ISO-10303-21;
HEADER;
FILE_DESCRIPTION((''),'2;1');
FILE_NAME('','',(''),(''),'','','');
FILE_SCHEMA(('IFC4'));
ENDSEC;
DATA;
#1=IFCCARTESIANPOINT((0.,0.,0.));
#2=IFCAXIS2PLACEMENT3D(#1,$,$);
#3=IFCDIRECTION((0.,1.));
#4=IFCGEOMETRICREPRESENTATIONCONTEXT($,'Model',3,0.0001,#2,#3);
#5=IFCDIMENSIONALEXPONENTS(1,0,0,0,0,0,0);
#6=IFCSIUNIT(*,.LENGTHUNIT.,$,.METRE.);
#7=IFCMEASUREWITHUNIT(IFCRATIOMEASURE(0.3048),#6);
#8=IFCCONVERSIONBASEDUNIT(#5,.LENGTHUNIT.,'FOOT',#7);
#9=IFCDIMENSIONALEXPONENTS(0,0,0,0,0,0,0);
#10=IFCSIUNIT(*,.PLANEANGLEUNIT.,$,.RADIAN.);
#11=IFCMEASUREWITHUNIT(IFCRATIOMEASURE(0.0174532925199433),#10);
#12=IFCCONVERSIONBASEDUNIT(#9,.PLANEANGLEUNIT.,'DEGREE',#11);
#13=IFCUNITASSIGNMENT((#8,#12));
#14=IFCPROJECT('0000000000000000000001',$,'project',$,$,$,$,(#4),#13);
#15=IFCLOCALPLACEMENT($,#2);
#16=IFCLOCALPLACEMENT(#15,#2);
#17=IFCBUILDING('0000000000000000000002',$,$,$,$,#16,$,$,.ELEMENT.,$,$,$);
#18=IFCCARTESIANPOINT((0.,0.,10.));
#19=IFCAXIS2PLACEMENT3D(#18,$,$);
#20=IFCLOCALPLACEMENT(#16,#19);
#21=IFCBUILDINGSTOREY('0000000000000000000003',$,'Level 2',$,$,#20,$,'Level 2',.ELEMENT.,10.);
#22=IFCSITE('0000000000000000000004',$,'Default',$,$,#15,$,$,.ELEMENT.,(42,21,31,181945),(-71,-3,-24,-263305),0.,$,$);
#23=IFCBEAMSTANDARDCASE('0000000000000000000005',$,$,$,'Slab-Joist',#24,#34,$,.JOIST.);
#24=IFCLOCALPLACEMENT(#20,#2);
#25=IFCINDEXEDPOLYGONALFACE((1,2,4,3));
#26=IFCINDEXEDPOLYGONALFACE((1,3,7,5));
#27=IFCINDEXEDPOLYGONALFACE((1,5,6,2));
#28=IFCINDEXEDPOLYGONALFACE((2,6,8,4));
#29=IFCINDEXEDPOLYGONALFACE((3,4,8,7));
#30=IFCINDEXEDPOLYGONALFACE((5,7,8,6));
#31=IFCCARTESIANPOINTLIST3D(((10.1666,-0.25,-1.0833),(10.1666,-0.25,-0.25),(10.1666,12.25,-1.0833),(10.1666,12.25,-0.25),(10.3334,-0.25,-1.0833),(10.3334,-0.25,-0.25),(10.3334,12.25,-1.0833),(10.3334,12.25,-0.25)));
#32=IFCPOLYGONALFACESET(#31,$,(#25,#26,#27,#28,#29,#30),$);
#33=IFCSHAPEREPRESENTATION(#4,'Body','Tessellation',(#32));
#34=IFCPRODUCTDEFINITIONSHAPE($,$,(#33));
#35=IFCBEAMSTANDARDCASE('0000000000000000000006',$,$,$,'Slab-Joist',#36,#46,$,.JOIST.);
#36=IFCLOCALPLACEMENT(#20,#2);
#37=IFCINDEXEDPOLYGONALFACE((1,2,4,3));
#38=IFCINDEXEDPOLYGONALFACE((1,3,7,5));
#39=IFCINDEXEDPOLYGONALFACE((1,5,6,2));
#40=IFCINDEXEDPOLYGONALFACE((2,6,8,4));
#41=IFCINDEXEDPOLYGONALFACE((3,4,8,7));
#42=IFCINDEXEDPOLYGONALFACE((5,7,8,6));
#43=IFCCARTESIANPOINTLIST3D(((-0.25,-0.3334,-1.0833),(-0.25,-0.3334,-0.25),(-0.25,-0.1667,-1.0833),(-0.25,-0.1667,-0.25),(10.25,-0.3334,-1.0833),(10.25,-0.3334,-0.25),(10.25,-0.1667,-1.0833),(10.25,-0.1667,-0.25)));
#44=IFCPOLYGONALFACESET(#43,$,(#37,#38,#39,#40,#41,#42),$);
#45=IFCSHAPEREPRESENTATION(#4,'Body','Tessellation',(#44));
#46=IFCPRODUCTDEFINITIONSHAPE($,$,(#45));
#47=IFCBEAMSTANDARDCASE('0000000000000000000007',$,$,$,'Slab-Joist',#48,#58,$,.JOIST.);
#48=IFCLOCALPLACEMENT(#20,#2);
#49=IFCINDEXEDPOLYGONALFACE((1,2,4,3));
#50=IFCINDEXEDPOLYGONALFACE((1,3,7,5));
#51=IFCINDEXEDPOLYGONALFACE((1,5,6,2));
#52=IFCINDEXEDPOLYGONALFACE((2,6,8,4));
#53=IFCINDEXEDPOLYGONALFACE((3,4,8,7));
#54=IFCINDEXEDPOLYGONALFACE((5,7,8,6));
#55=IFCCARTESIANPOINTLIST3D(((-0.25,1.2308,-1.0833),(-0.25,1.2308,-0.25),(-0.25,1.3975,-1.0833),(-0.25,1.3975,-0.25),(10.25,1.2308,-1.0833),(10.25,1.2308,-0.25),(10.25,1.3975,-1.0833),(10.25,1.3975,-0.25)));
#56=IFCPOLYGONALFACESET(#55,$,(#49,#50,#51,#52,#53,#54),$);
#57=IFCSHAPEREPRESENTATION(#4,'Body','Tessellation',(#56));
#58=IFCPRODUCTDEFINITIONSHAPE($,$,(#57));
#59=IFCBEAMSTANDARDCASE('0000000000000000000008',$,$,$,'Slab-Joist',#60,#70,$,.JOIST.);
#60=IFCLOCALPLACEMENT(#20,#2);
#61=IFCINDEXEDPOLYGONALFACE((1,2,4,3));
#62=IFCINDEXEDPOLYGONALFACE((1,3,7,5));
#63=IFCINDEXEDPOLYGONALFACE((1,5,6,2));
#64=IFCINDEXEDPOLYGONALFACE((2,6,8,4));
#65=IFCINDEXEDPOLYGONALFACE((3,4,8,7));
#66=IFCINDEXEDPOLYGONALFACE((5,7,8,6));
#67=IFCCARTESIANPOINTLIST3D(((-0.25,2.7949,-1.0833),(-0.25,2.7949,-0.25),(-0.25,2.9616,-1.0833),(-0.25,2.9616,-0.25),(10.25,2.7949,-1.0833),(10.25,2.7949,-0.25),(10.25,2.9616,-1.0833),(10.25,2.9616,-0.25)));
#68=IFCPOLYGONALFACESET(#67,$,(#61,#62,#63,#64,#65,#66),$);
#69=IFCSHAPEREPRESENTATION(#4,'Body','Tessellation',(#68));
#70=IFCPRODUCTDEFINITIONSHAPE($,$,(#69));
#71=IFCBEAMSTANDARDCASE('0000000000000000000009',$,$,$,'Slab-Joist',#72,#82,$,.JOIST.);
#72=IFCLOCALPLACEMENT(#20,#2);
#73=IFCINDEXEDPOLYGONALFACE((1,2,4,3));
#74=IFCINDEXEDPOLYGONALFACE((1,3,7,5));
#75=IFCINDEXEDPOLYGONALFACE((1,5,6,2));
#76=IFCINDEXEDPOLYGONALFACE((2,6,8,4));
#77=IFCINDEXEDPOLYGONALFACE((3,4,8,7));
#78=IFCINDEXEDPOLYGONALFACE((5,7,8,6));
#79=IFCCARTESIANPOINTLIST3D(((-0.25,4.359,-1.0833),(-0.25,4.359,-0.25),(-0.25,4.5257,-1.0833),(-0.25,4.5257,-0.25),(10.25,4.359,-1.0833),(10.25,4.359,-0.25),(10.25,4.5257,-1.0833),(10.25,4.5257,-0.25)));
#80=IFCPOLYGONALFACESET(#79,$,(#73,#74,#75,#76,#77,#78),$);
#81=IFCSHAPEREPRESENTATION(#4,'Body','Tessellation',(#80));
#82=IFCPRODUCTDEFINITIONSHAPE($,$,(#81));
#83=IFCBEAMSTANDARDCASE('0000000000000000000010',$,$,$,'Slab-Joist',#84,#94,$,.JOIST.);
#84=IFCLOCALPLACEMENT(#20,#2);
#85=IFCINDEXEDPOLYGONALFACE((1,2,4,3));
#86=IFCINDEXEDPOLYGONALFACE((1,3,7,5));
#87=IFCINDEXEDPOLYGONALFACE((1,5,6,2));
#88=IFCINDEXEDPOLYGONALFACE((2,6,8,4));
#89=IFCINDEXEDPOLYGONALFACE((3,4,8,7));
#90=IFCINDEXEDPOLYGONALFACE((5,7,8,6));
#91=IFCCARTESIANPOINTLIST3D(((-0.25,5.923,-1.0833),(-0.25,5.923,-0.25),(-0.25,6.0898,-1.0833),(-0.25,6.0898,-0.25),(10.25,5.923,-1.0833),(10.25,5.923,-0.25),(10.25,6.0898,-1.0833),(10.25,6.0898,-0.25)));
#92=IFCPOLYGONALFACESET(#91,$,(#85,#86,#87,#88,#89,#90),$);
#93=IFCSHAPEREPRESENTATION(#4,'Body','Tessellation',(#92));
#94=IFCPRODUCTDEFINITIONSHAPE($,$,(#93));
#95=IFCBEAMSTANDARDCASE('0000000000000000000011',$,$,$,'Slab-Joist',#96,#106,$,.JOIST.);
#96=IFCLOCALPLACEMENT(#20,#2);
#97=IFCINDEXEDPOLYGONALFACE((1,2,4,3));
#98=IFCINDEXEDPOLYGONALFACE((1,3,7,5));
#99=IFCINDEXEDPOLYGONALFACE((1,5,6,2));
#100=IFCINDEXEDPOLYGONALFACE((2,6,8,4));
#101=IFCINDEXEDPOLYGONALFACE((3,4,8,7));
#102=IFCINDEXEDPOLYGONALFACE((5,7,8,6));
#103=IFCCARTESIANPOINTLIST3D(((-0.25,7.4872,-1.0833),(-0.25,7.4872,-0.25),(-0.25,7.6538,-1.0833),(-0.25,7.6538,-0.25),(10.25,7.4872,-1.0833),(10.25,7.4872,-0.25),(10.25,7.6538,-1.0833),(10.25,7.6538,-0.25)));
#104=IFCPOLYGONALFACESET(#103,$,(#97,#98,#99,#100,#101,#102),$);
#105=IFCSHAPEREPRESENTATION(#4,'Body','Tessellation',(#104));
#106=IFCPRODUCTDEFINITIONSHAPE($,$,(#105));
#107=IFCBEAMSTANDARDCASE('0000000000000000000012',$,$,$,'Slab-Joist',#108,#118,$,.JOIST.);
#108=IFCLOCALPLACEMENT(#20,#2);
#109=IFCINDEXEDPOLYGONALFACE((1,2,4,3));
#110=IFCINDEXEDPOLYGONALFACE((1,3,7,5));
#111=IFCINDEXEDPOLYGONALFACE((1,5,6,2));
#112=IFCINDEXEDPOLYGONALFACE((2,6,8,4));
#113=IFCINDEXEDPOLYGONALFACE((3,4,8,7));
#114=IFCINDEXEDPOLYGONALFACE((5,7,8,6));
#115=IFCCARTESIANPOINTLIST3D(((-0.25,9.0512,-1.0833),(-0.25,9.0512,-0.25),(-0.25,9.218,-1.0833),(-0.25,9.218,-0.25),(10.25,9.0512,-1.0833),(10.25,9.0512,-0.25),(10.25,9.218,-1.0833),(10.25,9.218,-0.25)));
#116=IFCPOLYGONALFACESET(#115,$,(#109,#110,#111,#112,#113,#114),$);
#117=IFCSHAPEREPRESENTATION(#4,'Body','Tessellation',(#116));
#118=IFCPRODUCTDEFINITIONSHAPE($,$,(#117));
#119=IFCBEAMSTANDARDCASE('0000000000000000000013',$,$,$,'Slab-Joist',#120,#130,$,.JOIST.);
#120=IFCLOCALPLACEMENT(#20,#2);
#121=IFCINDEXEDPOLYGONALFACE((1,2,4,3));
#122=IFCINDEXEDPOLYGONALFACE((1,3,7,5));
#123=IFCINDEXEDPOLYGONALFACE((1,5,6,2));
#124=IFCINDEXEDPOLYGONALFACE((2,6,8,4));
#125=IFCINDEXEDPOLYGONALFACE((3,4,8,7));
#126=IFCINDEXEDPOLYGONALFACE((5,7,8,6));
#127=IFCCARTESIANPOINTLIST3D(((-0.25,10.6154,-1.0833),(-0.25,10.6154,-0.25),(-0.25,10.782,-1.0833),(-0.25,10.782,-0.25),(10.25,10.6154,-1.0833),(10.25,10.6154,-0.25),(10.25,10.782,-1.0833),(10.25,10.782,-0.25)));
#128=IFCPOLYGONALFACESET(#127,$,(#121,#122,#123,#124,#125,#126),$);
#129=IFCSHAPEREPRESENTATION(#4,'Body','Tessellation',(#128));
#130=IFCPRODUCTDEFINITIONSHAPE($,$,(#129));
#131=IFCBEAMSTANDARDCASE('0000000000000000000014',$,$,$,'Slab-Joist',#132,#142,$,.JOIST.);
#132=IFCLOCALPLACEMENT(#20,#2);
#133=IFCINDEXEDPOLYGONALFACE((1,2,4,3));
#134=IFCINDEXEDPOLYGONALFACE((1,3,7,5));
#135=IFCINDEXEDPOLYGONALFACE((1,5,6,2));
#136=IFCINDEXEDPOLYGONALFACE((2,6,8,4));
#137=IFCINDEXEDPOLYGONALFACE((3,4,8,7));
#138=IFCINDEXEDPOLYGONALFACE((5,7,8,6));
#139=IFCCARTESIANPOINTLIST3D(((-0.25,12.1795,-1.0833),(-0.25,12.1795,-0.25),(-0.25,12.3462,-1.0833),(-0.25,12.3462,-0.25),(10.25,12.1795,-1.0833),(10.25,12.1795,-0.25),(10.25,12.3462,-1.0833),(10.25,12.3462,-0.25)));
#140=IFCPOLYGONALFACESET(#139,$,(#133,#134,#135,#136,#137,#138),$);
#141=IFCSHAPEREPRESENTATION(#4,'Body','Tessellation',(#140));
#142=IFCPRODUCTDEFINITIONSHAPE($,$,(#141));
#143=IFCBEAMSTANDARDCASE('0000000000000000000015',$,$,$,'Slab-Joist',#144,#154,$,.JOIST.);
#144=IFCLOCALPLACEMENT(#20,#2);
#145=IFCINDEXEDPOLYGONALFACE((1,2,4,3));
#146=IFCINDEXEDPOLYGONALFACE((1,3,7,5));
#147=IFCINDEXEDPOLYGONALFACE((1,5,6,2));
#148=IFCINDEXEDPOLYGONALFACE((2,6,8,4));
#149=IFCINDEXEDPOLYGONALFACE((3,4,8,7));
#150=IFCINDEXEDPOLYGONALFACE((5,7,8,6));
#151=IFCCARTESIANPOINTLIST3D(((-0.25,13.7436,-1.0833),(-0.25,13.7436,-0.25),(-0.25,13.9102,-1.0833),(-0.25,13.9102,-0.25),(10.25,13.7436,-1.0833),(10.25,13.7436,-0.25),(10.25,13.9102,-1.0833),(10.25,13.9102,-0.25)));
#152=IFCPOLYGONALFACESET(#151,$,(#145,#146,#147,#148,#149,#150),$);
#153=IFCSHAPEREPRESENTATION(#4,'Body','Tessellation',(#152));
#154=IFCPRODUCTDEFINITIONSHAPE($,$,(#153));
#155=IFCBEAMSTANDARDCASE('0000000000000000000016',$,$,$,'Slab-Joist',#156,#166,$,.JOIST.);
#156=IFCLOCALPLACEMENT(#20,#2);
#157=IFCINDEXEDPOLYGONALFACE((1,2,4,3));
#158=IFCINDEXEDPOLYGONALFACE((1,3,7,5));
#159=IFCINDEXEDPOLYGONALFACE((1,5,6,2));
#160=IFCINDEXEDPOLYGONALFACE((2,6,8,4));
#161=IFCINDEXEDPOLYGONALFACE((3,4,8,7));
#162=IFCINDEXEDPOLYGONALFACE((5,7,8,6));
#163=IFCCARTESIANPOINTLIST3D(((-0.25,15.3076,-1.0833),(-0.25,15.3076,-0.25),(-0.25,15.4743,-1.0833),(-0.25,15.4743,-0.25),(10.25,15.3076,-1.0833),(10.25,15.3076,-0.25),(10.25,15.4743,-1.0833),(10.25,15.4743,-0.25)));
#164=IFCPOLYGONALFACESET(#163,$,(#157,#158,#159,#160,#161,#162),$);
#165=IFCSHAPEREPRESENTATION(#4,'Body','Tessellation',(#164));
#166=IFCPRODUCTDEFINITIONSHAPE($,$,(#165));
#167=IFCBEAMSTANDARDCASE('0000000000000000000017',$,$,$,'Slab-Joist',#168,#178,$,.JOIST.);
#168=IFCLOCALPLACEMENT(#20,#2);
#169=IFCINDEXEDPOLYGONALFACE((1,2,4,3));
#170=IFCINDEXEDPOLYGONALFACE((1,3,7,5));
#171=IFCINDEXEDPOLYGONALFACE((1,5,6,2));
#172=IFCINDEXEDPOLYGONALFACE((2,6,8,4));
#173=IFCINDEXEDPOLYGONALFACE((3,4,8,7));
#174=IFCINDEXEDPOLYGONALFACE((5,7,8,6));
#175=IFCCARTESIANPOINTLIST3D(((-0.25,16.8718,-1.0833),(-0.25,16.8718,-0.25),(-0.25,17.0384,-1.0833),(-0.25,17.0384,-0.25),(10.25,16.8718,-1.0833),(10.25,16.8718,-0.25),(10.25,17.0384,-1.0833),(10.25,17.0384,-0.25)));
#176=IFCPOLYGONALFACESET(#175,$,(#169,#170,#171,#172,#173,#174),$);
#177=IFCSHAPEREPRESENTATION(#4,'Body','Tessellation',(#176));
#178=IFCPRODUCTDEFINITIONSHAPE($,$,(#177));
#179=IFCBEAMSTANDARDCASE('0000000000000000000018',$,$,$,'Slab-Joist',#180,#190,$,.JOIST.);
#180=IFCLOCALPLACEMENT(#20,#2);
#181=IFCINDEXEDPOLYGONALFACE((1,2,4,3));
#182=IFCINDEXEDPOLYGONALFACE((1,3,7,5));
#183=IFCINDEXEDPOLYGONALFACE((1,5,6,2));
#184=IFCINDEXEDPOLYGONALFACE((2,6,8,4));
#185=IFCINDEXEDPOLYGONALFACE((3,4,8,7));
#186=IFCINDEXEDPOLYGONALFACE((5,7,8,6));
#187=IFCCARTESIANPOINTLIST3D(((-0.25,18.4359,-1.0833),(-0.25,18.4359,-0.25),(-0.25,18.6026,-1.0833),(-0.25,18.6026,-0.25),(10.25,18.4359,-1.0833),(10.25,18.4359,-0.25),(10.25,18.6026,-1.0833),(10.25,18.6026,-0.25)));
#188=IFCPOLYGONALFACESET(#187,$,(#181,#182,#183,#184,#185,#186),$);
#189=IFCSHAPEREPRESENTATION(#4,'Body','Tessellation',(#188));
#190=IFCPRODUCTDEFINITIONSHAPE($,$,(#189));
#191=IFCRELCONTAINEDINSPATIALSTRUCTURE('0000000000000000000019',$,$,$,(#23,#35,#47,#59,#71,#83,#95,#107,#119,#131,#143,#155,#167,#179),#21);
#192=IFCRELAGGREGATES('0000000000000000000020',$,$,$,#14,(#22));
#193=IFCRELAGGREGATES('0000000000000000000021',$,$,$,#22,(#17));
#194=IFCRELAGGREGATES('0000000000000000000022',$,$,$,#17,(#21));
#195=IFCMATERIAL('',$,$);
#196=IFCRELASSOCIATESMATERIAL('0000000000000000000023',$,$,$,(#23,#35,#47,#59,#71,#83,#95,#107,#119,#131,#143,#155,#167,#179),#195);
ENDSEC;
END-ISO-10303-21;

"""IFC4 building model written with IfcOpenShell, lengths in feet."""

from ifc_helpers import new_model, entity, si_unit, converted_unit, direction, frame, origin, origin_with_axes, place, context, project, spatial, rectangle, extrude, material, element, save


model = new_model("IFC4")

# Units and contexts
model_context = context("Model", 3, precision=0.0001, world=origin(), true_north=direction((0.0, 1.0)))
ifc_project = project(units=[converted_unit("LENGTHUNIT", "FOOT", entity("IfcRatioMeasure", 0.3048), si_unit("LENGTHUNIT", "METRE"), dimensions=[1, 0, 0, 0, 0, 0, 0]), converted_unit("PLANEANGLEUNIT", "DEGREE", entity("IfcRatioMeasure", 0.0174532925199433), si_unit("PLANEANGLEUNIT", "RADIAN"), dimensions=[0, 0, 0, 0, 0, 0, 0])], contexts=[model_context])

# Site, building, storey
site_placement = place(None, origin())
site = spatial("IfcSite", under=ifc_project, at=site_placement, Name="Default", CompositionType="ELEMENT", RefLatitude=(42, 21, 31, 181945), RefLongitude=(-71, -3, -24, -263305), RefElevation=0.0)
building_placement = place(site_placement, origin())
building = spatial("IfcBuilding", under=site, at=building_placement, CompositionType="ELEMENT")
storey_placement = place(building_placement, frame((0.0, 0.0, 10.0)))
storey = spatial("IfcBuildingStorey", under=building, at=storey_placement, Name="Level 2", LongName="Level 2", CompositionType="ELEMENT", Elevation=10.0)

# Beams
ifc_material = material(Name="")
placement_1 = place(storey_placement, frame((10.25, -0.25, 0.0), z_axis=(0.0, 0.0, 1.0), x_axis=(1.0, 0.0, 0.0)))
beam_1_placement = place(placement_1, frame((0.0, 0.0, -0.6667), z_axis=(0.0, 1.0, 0.0), x_axis=(-1.0, 0.0, 0.0)))
element("IfcBeamStandardCase", 1, at=beam_1_placement, inside=storey, material=ifc_material, ObjectType="Slab-Joist", PredefinedType="JOIST", context=model_context, shape_type="SweptSolid", body=[
    extrude(rectangle(XDim=0.1667, YDim=0.8333), origin_with_axes(), (0.0, 0.0, 1.0), 12.5),
])
placement_2 = place(storey_placement, frame((-0.25, -0.25, 0.0), z_axis=(0.0, 0.0, 1.0), x_axis=(1.0, 0.0, 0.0)))
beam_2_placement = place(placement_2, frame((0.0, 0.0, -0.6667), z_axis=(1.0, 0.0, 0.0), x_axis=(0.0, 1.0, 0.0)))
element("IfcBeamStandardCase", 2, at=beam_2_placement, inside=storey, material=ifc_material, ObjectType="Slab-Joist", PredefinedType="JOIST", context=model_context, shape_type="SweptSolid", body=[
    extrude(rectangle(XDim=0.1667, YDim=0.8333), origin_with_axes(), (0.0, 0.0, 1.0), 10.5),
])
placement_3 = place(storey_placement, frame((-0.25, -0.25, 0.0), z_axis=(0.0, 0.0, 1.0), x_axis=(1.0, 0.0, 0.0)))
beam_3_placement = place(placement_3, frame((0.0, 1.5641, -0.6667), z_axis=(1.0, 0.0, 0.0), x_axis=(0.0, 1.0, 0.0)))
element("IfcBeamStandardCase", 3, at=beam_3_placement, inside=storey, material=ifc_material, ObjectType="Slab-Joist", PredefinedType="JOIST", context=model_context, shape_type="SweptSolid", body=[
    extrude(rectangle(XDim=0.1667, YDim=0.8333), origin_with_axes(), (0.0, 0.0, 1.0), 10.5),
])
placement_4 = place(storey_placement, frame((-0.25, -0.25, 0.0), z_axis=(0.0, 0.0, 1.0), x_axis=(1.0, 0.0, 0.0)))
beam_4_placement = place(placement_4, frame((0.0, 3.1282, -0.6667), z_axis=(1.0, 0.0, 0.0), x_axis=(0.0, 1.0, 0.0)))
element("IfcBeamStandardCase", 4, at=beam_4_placement, inside=storey, material=ifc_material, ObjectType="Slab-Joist", PredefinedType="JOIST", context=model_context, shape_type="SweptSolid", body=[
    extrude(rectangle(XDim=0.1667, YDim=0.8333), origin_with_axes(), (0.0, 0.0, 1.0), 10.5),
])
placement_5 = place(storey_placement, frame((-0.25, -0.25, 0.0), z_axis=(0.0, 0.0, 1.0), x_axis=(1.0, 0.0, 0.0)))
beam_5_placement = place(placement_5, frame((0.0, 4.6923, -0.6667), z_axis=(1.0, 0.0, 0.0), x_axis=(0.0, 1.0, 0.0)))
element("IfcBeamStandardCase", 5, at=beam_5_placement, inside=storey, material=ifc_material, ObjectType="Slab-Joist", PredefinedType="JOIST", context=model_context, shape_type="SweptSolid", body=[
    extrude(rectangle(XDim=0.1667, YDim=0.8333), origin_with_axes(), (0.0, 0.0, 1.0), 10.5),
])
placement_6 = place(storey_placement, frame((-0.25, -0.25, 0.0), z_axis=(0.0, 0.0, 1.0), x_axis=(1.0, 0.0, 0.0)))
beam_6_placement = place(placement_6, frame((0.0, 6.2564, -0.6667), z_axis=(1.0, 0.0, 0.0), x_axis=(0.0, 1.0, 0.0)))
element("IfcBeamStandardCase", 6, at=beam_6_placement, inside=storey, material=ifc_material, ObjectType="Slab-Joist", PredefinedType="JOIST", context=model_context, shape_type="SweptSolid", body=[
    extrude(rectangle(XDim=0.1667, YDim=0.8333), origin_with_axes(), (0.0, 0.0, 1.0), 10.5),
])
placement_7 = place(storey_placement, frame((-0.25, -0.25, 0.0), z_axis=(0.0, 0.0, 1.0), x_axis=(1.0, 0.0, 0.0)))
beam_7_placement = place(placement_7, frame((0.0, 7.8205, -0.6667), z_axis=(1.0, 0.0, 0.0), x_axis=(0.0, 1.0, 0.0)))
element("IfcBeamStandardCase", 7, at=beam_7_placement, inside=storey, material=ifc_material, ObjectType="Slab-Joist", PredefinedType="JOIST", context=model_context, shape_type="SweptSolid", body=[
    extrude(rectangle(XDim=0.1667, YDim=0.8333), origin_with_axes(), (0.0, 0.0, 1.0), 10.5),
])
placement_8 = place(storey_placement, frame((-0.25, -0.25, 0.0), z_axis=(0.0, 0.0, 1.0), x_axis=(1.0, 0.0, 0.0)))
beam_8_placement = place(placement_8, frame((0.0, 9.3846, -0.6667), z_axis=(1.0, 0.0, 0.0), x_axis=(0.0, 1.0, 0.0)))
element("IfcBeamStandardCase", 8, at=beam_8_placement, inside=storey, material=ifc_material, ObjectType="Slab-Joist", PredefinedType="JOIST", context=model_context, shape_type="SweptSolid", body=[
    extrude(rectangle(XDim=0.1667, YDim=0.8333), origin_with_axes(), (0.0, 0.0, 1.0), 10.5),
])
placement_9 = place(storey_placement, frame((-0.25, -0.25, 0.0), z_axis=(0.0, 0.0, 1.0), x_axis=(1.0, 0.0, 0.0)))
beam_9_placement = place(placement_9, frame((0.0, 10.9487, -0.6667), z_axis=(1.0, 0.0, 0.0), x_axis=(0.0, 1.0, 0.0)))
element("IfcBeamStandardCase", 9, at=beam_9_placement, inside=storey, material=ifc_material, ObjectType="Slab-Joist", PredefinedType="JOIST", context=model_context, shape_type="SweptSolid", body=[
    extrude(rectangle(XDim=0.1667, YDim=0.8333), origin_with_axes(), (0.0, 0.0, 1.0), 10.5),
])
placement_10 = place(storey_placement, frame((-0.25, -0.25, 0.0), z_axis=(0.0, 0.0, 1.0), x_axis=(1.0, 0.0, 0.0)))
beam_10_placement = place(placement_10, frame((0.0, 12.5128, -0.6667), z_axis=(1.0, 0.0, 0.0), x_axis=(0.0, 1.0, 0.0)))
element("IfcBeamStandardCase", 10, at=beam_10_placement, inside=storey, material=ifc_material, ObjectType="Slab-Joist", PredefinedType="JOIST", context=model_context, shape_type="SweptSolid", body=[
    extrude(rectangle(XDim=0.1667, YDim=0.8333), origin_with_axes(), (0.0, 0.0, 1.0), 10.5),
])
placement_11 = place(storey_placement, frame((-0.25, -0.25, 0.0), z_axis=(0.0, 0.0, 1.0), x_axis=(1.0, 0.0, 0.0)))
beam_11_placement = place(placement_11, frame((0.0, 14.0769, -0.6667), z_axis=(1.0, 0.0, 0.0), x_axis=(0.0, 1.0, 0.0)))
element("IfcBeamStandardCase", 11, at=beam_11_placement, inside=storey, material=ifc_material, ObjectType="Slab-Joist", PredefinedType="JOIST", context=model_context, shape_type="SweptSolid", body=[
    extrude(rectangle(XDim=0.1667, YDim=0.8333), origin_with_axes(), (0.0, 0.0, 1.0), 10.5),
])
placement_12 = place(storey_placement, frame((-0.25, -0.25, 0.0), z_axis=(0.0, 0.0, 1.0), x_axis=(1.0, 0.0, 0.0)))
beam_12_placement = place(placement_12, frame((0.0, 15.641, -0.6667), z_axis=(1.0, 0.0, 0.0), x_axis=(0.0, 1.0, 0.0)))
element("IfcBeamStandardCase", 12, at=beam_12_placement, inside=storey, material=ifc_material, ObjectType="Slab-Joist", PredefinedType="JOIST", context=model_context, shape_type="SweptSolid", body=[
    extrude(rectangle(XDim=0.1667, YDim=0.8333), origin_with_axes(), (0.0, 0.0, 1.0), 10.5),
])
placement_13 = place(storey_placement, frame((-0.25, -0.25, 0.0), z_axis=(0.0, 0.0, 1.0), x_axis=(1.0, 0.0, 0.0)))
beam_13_placement = place(placement_13, frame((0.0, 17.2051, -0.6667), z_axis=(1.0, 0.0, 0.0), x_axis=(0.0, 1.0, 0.0)))
element("IfcBeamStandardCase", 13, at=beam_13_placement, inside=storey, material=ifc_material, ObjectType="Slab-Joist", PredefinedType="JOIST", context=model_context, shape_type="SweptSolid", body=[
    extrude(rectangle(XDim=0.1667, YDim=0.8333), origin_with_axes(), (0.0, 0.0, 1.0), 10.5),
])
placement_14 = place(storey_placement, frame((-0.25, -0.25, 0.0), z_axis=(0.0, 0.0, 1.0), x_axis=(1.0, 0.0, 0.0)))
beam_14_placement = place(placement_14, frame((0.0, 18.7692, -0.6667), z_axis=(1.0, 0.0, 0.0), x_axis=(0.0, 1.0, 0.0)))
element("IfcBeamStandardCase", 14, at=beam_14_placement, inside=storey, material=ifc_material, ObjectType="Slab-Joist", PredefinedType="JOIST", context=model_context, shape_type="SweptSolid", body=[
    extrude(rectangle(XDim=0.1667, YDim=0.8333), origin_with_axes(), (0.0, 0.0, 1.0), 10.5),
])

save(model, "model.ifc")
